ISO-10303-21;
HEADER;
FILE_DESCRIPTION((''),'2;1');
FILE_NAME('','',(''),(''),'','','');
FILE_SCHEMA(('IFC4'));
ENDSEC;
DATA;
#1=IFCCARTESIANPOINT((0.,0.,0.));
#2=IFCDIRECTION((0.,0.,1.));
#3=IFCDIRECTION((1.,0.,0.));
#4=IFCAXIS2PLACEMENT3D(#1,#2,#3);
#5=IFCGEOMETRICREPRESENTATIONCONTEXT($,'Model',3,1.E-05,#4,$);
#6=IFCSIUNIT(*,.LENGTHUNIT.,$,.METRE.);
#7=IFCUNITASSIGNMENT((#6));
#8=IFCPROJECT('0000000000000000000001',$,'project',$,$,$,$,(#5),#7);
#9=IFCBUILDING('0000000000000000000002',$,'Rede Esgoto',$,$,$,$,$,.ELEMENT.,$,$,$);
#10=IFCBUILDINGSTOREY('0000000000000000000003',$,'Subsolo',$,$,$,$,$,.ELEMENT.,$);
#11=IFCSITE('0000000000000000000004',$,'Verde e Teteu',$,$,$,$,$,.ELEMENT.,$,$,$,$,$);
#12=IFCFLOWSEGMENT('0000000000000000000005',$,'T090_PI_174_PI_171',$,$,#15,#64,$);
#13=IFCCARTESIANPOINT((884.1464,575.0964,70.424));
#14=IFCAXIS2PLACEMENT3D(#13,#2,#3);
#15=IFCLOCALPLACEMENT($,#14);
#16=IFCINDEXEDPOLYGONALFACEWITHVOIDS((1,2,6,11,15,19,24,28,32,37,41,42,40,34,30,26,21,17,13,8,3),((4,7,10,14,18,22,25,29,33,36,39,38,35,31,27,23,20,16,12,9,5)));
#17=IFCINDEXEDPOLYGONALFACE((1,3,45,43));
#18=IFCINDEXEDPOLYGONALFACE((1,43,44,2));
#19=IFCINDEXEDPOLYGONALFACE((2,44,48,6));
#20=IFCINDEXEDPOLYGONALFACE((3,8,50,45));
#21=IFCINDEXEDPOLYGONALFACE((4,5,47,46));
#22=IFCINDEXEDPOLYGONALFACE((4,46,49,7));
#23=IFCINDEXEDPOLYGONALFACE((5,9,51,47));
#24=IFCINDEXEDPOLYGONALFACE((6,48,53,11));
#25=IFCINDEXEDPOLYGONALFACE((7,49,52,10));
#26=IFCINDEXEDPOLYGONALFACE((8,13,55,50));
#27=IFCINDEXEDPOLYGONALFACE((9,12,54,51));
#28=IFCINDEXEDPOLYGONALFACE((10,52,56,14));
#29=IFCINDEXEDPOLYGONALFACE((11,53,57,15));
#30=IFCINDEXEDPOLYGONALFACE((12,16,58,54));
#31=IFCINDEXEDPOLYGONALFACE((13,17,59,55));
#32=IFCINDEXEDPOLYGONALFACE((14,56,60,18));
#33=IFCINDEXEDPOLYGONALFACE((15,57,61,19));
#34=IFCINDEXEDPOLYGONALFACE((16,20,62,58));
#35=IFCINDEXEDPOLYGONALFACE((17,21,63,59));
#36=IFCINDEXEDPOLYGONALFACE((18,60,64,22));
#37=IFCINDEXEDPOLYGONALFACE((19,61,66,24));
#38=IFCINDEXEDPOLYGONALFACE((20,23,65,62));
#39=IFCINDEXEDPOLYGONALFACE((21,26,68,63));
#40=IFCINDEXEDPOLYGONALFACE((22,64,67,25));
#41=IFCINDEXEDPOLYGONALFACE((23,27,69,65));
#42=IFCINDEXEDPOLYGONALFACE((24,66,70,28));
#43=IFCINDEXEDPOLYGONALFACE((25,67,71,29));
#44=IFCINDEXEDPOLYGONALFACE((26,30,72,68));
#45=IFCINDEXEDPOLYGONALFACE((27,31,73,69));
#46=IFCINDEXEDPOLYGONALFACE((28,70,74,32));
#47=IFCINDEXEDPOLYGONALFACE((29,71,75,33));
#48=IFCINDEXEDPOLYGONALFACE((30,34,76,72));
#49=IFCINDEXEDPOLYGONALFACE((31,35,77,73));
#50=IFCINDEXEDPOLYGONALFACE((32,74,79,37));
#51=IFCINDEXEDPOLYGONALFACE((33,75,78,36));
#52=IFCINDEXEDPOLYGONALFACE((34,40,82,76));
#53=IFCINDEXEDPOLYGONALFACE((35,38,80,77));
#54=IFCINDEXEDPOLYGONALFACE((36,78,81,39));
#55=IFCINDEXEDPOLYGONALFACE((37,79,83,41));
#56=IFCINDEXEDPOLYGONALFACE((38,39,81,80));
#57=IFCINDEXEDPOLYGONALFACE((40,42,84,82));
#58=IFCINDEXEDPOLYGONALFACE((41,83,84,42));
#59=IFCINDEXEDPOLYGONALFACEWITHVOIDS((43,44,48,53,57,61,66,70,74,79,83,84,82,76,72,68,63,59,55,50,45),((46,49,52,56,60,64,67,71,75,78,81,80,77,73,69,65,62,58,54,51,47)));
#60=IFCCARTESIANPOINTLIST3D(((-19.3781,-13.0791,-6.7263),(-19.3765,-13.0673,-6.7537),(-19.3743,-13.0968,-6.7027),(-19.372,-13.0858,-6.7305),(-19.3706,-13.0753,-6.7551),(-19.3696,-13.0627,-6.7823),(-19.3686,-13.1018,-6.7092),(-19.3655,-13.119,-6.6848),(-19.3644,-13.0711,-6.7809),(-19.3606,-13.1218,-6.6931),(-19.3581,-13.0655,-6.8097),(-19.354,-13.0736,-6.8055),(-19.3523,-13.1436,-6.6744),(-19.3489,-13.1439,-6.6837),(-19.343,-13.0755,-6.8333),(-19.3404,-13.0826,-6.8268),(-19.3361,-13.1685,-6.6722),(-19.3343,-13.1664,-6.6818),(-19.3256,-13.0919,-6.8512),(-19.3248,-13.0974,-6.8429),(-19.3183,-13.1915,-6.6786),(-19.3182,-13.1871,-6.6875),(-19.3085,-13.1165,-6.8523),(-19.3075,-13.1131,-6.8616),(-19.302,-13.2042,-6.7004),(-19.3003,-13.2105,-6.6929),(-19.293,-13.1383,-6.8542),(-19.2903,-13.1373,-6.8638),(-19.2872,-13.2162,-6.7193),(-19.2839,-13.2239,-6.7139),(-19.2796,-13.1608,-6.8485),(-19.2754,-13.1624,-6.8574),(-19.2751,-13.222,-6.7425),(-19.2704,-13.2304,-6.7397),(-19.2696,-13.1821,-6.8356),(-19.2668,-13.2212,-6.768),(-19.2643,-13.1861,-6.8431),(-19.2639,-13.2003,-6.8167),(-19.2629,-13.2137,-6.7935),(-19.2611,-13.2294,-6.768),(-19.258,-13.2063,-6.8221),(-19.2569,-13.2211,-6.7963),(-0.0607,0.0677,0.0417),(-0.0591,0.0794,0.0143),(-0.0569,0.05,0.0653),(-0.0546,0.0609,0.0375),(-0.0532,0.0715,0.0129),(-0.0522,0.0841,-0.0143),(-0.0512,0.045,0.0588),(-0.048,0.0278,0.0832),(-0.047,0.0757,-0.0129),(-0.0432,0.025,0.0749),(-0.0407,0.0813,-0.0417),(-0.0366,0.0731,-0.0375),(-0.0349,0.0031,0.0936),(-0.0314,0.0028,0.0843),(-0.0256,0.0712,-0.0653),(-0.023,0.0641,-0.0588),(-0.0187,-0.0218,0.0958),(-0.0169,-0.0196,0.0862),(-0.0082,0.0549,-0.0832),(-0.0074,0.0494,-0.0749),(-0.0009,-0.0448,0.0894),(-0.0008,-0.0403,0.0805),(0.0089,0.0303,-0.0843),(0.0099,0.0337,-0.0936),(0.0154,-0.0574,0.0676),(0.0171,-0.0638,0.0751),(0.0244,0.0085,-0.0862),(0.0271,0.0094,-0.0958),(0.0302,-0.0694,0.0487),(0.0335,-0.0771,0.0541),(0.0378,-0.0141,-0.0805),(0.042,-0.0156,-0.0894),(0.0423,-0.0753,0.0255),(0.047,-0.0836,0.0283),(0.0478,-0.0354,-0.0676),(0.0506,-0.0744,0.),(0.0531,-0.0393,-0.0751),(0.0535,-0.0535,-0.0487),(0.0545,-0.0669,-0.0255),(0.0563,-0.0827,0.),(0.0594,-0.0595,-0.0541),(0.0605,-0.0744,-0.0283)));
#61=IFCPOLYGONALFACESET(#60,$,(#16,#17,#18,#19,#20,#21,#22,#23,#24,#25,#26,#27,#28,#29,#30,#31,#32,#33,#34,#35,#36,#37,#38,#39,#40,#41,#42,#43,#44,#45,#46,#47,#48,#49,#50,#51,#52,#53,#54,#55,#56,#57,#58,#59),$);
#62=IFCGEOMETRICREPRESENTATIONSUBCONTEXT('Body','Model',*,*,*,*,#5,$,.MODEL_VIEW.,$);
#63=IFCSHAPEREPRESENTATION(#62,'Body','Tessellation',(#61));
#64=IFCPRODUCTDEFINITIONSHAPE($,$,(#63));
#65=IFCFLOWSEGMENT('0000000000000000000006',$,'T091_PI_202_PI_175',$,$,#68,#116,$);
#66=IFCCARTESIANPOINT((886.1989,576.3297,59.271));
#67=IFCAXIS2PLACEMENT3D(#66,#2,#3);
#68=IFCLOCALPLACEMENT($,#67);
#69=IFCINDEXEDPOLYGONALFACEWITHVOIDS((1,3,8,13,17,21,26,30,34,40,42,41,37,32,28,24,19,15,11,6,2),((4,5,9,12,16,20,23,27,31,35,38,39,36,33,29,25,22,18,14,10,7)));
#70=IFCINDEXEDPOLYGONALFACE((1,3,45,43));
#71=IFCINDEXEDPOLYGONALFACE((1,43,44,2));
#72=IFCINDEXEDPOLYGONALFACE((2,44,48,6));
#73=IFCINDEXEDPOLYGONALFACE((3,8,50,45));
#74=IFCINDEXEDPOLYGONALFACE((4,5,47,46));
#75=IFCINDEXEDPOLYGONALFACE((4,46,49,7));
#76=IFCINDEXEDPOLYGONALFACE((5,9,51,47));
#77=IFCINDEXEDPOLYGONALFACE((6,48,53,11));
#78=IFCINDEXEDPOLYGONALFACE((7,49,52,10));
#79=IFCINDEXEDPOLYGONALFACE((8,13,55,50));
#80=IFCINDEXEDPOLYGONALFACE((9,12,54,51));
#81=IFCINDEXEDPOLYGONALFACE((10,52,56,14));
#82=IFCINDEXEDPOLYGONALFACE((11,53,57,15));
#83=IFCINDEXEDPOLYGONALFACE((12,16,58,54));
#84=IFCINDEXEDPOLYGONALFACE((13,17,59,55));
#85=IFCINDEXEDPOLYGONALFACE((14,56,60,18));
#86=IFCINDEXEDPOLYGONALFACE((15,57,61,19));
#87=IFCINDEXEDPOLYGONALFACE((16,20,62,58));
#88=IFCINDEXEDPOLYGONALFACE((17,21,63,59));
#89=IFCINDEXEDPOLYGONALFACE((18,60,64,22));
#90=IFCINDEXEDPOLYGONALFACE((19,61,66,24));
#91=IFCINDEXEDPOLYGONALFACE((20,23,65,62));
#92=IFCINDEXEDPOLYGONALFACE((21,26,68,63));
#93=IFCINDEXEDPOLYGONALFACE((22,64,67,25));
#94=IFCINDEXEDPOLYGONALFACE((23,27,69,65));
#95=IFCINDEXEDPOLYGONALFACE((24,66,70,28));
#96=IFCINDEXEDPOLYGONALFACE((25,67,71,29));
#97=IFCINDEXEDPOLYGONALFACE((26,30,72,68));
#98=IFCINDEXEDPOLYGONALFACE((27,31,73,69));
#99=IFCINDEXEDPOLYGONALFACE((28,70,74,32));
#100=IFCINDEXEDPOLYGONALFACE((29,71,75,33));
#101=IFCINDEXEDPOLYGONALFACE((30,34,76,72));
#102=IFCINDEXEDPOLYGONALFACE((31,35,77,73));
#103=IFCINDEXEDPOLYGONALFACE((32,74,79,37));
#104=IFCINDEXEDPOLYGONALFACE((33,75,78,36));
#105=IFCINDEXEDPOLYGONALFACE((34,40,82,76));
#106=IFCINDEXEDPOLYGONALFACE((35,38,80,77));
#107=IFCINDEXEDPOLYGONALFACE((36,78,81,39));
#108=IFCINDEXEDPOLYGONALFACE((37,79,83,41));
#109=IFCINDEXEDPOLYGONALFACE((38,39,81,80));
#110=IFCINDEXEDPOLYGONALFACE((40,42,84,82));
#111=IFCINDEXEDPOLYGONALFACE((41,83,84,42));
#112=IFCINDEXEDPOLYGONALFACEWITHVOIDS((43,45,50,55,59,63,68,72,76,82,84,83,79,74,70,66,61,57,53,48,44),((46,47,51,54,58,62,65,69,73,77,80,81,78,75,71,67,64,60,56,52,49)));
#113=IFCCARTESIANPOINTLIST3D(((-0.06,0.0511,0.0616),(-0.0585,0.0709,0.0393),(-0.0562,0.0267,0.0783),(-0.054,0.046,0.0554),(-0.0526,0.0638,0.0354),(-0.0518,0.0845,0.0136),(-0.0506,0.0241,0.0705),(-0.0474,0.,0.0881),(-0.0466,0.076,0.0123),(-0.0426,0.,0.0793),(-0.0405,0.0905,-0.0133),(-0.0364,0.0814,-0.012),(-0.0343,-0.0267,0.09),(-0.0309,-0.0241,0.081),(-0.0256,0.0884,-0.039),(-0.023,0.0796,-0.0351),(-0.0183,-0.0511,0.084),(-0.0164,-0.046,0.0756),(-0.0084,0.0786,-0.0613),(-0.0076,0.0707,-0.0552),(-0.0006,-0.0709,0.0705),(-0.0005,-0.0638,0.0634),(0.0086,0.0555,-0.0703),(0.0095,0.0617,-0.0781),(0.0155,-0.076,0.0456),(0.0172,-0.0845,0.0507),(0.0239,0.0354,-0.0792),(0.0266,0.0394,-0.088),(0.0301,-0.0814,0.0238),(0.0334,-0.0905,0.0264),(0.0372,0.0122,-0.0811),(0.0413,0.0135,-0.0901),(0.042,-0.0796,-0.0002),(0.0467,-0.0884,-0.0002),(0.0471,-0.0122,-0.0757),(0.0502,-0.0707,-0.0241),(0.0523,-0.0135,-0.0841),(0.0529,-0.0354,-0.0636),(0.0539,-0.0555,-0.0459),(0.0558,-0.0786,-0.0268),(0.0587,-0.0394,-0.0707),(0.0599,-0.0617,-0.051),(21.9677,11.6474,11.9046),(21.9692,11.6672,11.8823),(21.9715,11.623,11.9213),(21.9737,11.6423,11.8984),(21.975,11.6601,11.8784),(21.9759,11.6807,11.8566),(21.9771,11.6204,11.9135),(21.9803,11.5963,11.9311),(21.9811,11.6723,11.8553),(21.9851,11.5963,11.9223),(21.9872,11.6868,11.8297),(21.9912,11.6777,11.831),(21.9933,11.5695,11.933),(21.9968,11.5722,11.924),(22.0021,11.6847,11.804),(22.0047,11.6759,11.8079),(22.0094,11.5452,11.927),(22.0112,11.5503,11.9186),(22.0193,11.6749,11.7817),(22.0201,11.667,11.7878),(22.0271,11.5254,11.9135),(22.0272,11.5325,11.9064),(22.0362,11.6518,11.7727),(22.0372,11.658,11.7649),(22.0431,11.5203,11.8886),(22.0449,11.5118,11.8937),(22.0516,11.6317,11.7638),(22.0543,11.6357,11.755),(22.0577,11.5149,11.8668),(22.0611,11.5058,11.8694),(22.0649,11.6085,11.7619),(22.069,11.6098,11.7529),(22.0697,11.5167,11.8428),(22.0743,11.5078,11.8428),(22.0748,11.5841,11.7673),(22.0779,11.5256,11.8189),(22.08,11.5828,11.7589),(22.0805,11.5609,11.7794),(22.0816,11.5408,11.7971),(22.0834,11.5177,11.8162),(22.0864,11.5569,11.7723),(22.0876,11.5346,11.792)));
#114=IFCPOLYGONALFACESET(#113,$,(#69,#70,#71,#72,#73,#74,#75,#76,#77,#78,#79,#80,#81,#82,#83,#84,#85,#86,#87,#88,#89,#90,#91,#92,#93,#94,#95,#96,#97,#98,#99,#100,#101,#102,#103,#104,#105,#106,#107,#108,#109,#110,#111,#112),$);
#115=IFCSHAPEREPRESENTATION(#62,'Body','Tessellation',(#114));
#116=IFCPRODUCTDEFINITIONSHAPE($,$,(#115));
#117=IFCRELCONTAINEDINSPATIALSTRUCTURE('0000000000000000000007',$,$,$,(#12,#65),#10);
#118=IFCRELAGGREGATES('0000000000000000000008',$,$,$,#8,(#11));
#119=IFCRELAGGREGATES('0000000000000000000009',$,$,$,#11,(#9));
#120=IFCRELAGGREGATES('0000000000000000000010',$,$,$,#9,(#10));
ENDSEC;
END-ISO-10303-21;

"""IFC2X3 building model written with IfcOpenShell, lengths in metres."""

from ifc_helpers import new_model, entity, si_unit, frame, origin_with_axes, place, context, subcontext, project, spatial, element, save


model = new_model("IFC2X3")

# Units and contexts
model_context = context("Model", 3, precision=1e-05, world=origin_with_axes())
body_context = subcontext(model_context, "Body", "Model", "MODEL_VIEW")
ifc_project = project(units=[si_unit("LENGTHUNIT", "METRE")], contexts=[model_context])

# Site, building, storey
site = spatial("IfcSite", under=ifc_project, Name="Verde e Teteu", CompositionType="ELEMENT")
building = spatial("IfcBuilding", under=site, Name="Rede Esgoto", CompositionType="ELEMENT")
storey = spatial("IfcBuildingStorey", under=building, Name="Subsolo", CompositionType="ELEMENT")

# Flow segments
flow_segment_1_placement = place(None, frame((884.1464, 575.0964, 70.424), z_axis=(0.0, 0.0, 1.0), x_axis=(1.0, 0.0, 0.0)))
element("IfcFlowSegment", 1, at=flow_segment_1_placement, inside=storey, Name="T090_PI_174_PI_171", context=body_context, shape_type="SweptSolid", body=[
    entity("IfcSweptDiskSolid", entity("IfcPolyline", [entity("IfcCartesianPoint", [0.0, 0.0, 0.0]), entity("IfcCartesianPoint", [-19.3174, -13.1468, -6.768])]), 0.1, 0.09),
])
flow_segment_2_placement = place(None, frame((886.1989, 576.3297, 59.271), z_axis=(0.0, 0.0, 1.0), x_axis=(1.0, 0.0, 0.0)))
element("IfcFlowSegment", 2, at=flow_segment_2_placement, inside=storey, Name="T091_PI_202_PI_175", context=body_context, shape_type="SweptSolid", body=[
    entity("IfcSweptDiskSolid", entity("IfcPolyline", [entity("IfcCartesianPoint", [0.0, 0.0, 0.0]), entity("IfcCartesianPoint", [22.0277, 11.5963, 11.843])]), 0.1, 0.09),
])

save(model, "model.ifc")
